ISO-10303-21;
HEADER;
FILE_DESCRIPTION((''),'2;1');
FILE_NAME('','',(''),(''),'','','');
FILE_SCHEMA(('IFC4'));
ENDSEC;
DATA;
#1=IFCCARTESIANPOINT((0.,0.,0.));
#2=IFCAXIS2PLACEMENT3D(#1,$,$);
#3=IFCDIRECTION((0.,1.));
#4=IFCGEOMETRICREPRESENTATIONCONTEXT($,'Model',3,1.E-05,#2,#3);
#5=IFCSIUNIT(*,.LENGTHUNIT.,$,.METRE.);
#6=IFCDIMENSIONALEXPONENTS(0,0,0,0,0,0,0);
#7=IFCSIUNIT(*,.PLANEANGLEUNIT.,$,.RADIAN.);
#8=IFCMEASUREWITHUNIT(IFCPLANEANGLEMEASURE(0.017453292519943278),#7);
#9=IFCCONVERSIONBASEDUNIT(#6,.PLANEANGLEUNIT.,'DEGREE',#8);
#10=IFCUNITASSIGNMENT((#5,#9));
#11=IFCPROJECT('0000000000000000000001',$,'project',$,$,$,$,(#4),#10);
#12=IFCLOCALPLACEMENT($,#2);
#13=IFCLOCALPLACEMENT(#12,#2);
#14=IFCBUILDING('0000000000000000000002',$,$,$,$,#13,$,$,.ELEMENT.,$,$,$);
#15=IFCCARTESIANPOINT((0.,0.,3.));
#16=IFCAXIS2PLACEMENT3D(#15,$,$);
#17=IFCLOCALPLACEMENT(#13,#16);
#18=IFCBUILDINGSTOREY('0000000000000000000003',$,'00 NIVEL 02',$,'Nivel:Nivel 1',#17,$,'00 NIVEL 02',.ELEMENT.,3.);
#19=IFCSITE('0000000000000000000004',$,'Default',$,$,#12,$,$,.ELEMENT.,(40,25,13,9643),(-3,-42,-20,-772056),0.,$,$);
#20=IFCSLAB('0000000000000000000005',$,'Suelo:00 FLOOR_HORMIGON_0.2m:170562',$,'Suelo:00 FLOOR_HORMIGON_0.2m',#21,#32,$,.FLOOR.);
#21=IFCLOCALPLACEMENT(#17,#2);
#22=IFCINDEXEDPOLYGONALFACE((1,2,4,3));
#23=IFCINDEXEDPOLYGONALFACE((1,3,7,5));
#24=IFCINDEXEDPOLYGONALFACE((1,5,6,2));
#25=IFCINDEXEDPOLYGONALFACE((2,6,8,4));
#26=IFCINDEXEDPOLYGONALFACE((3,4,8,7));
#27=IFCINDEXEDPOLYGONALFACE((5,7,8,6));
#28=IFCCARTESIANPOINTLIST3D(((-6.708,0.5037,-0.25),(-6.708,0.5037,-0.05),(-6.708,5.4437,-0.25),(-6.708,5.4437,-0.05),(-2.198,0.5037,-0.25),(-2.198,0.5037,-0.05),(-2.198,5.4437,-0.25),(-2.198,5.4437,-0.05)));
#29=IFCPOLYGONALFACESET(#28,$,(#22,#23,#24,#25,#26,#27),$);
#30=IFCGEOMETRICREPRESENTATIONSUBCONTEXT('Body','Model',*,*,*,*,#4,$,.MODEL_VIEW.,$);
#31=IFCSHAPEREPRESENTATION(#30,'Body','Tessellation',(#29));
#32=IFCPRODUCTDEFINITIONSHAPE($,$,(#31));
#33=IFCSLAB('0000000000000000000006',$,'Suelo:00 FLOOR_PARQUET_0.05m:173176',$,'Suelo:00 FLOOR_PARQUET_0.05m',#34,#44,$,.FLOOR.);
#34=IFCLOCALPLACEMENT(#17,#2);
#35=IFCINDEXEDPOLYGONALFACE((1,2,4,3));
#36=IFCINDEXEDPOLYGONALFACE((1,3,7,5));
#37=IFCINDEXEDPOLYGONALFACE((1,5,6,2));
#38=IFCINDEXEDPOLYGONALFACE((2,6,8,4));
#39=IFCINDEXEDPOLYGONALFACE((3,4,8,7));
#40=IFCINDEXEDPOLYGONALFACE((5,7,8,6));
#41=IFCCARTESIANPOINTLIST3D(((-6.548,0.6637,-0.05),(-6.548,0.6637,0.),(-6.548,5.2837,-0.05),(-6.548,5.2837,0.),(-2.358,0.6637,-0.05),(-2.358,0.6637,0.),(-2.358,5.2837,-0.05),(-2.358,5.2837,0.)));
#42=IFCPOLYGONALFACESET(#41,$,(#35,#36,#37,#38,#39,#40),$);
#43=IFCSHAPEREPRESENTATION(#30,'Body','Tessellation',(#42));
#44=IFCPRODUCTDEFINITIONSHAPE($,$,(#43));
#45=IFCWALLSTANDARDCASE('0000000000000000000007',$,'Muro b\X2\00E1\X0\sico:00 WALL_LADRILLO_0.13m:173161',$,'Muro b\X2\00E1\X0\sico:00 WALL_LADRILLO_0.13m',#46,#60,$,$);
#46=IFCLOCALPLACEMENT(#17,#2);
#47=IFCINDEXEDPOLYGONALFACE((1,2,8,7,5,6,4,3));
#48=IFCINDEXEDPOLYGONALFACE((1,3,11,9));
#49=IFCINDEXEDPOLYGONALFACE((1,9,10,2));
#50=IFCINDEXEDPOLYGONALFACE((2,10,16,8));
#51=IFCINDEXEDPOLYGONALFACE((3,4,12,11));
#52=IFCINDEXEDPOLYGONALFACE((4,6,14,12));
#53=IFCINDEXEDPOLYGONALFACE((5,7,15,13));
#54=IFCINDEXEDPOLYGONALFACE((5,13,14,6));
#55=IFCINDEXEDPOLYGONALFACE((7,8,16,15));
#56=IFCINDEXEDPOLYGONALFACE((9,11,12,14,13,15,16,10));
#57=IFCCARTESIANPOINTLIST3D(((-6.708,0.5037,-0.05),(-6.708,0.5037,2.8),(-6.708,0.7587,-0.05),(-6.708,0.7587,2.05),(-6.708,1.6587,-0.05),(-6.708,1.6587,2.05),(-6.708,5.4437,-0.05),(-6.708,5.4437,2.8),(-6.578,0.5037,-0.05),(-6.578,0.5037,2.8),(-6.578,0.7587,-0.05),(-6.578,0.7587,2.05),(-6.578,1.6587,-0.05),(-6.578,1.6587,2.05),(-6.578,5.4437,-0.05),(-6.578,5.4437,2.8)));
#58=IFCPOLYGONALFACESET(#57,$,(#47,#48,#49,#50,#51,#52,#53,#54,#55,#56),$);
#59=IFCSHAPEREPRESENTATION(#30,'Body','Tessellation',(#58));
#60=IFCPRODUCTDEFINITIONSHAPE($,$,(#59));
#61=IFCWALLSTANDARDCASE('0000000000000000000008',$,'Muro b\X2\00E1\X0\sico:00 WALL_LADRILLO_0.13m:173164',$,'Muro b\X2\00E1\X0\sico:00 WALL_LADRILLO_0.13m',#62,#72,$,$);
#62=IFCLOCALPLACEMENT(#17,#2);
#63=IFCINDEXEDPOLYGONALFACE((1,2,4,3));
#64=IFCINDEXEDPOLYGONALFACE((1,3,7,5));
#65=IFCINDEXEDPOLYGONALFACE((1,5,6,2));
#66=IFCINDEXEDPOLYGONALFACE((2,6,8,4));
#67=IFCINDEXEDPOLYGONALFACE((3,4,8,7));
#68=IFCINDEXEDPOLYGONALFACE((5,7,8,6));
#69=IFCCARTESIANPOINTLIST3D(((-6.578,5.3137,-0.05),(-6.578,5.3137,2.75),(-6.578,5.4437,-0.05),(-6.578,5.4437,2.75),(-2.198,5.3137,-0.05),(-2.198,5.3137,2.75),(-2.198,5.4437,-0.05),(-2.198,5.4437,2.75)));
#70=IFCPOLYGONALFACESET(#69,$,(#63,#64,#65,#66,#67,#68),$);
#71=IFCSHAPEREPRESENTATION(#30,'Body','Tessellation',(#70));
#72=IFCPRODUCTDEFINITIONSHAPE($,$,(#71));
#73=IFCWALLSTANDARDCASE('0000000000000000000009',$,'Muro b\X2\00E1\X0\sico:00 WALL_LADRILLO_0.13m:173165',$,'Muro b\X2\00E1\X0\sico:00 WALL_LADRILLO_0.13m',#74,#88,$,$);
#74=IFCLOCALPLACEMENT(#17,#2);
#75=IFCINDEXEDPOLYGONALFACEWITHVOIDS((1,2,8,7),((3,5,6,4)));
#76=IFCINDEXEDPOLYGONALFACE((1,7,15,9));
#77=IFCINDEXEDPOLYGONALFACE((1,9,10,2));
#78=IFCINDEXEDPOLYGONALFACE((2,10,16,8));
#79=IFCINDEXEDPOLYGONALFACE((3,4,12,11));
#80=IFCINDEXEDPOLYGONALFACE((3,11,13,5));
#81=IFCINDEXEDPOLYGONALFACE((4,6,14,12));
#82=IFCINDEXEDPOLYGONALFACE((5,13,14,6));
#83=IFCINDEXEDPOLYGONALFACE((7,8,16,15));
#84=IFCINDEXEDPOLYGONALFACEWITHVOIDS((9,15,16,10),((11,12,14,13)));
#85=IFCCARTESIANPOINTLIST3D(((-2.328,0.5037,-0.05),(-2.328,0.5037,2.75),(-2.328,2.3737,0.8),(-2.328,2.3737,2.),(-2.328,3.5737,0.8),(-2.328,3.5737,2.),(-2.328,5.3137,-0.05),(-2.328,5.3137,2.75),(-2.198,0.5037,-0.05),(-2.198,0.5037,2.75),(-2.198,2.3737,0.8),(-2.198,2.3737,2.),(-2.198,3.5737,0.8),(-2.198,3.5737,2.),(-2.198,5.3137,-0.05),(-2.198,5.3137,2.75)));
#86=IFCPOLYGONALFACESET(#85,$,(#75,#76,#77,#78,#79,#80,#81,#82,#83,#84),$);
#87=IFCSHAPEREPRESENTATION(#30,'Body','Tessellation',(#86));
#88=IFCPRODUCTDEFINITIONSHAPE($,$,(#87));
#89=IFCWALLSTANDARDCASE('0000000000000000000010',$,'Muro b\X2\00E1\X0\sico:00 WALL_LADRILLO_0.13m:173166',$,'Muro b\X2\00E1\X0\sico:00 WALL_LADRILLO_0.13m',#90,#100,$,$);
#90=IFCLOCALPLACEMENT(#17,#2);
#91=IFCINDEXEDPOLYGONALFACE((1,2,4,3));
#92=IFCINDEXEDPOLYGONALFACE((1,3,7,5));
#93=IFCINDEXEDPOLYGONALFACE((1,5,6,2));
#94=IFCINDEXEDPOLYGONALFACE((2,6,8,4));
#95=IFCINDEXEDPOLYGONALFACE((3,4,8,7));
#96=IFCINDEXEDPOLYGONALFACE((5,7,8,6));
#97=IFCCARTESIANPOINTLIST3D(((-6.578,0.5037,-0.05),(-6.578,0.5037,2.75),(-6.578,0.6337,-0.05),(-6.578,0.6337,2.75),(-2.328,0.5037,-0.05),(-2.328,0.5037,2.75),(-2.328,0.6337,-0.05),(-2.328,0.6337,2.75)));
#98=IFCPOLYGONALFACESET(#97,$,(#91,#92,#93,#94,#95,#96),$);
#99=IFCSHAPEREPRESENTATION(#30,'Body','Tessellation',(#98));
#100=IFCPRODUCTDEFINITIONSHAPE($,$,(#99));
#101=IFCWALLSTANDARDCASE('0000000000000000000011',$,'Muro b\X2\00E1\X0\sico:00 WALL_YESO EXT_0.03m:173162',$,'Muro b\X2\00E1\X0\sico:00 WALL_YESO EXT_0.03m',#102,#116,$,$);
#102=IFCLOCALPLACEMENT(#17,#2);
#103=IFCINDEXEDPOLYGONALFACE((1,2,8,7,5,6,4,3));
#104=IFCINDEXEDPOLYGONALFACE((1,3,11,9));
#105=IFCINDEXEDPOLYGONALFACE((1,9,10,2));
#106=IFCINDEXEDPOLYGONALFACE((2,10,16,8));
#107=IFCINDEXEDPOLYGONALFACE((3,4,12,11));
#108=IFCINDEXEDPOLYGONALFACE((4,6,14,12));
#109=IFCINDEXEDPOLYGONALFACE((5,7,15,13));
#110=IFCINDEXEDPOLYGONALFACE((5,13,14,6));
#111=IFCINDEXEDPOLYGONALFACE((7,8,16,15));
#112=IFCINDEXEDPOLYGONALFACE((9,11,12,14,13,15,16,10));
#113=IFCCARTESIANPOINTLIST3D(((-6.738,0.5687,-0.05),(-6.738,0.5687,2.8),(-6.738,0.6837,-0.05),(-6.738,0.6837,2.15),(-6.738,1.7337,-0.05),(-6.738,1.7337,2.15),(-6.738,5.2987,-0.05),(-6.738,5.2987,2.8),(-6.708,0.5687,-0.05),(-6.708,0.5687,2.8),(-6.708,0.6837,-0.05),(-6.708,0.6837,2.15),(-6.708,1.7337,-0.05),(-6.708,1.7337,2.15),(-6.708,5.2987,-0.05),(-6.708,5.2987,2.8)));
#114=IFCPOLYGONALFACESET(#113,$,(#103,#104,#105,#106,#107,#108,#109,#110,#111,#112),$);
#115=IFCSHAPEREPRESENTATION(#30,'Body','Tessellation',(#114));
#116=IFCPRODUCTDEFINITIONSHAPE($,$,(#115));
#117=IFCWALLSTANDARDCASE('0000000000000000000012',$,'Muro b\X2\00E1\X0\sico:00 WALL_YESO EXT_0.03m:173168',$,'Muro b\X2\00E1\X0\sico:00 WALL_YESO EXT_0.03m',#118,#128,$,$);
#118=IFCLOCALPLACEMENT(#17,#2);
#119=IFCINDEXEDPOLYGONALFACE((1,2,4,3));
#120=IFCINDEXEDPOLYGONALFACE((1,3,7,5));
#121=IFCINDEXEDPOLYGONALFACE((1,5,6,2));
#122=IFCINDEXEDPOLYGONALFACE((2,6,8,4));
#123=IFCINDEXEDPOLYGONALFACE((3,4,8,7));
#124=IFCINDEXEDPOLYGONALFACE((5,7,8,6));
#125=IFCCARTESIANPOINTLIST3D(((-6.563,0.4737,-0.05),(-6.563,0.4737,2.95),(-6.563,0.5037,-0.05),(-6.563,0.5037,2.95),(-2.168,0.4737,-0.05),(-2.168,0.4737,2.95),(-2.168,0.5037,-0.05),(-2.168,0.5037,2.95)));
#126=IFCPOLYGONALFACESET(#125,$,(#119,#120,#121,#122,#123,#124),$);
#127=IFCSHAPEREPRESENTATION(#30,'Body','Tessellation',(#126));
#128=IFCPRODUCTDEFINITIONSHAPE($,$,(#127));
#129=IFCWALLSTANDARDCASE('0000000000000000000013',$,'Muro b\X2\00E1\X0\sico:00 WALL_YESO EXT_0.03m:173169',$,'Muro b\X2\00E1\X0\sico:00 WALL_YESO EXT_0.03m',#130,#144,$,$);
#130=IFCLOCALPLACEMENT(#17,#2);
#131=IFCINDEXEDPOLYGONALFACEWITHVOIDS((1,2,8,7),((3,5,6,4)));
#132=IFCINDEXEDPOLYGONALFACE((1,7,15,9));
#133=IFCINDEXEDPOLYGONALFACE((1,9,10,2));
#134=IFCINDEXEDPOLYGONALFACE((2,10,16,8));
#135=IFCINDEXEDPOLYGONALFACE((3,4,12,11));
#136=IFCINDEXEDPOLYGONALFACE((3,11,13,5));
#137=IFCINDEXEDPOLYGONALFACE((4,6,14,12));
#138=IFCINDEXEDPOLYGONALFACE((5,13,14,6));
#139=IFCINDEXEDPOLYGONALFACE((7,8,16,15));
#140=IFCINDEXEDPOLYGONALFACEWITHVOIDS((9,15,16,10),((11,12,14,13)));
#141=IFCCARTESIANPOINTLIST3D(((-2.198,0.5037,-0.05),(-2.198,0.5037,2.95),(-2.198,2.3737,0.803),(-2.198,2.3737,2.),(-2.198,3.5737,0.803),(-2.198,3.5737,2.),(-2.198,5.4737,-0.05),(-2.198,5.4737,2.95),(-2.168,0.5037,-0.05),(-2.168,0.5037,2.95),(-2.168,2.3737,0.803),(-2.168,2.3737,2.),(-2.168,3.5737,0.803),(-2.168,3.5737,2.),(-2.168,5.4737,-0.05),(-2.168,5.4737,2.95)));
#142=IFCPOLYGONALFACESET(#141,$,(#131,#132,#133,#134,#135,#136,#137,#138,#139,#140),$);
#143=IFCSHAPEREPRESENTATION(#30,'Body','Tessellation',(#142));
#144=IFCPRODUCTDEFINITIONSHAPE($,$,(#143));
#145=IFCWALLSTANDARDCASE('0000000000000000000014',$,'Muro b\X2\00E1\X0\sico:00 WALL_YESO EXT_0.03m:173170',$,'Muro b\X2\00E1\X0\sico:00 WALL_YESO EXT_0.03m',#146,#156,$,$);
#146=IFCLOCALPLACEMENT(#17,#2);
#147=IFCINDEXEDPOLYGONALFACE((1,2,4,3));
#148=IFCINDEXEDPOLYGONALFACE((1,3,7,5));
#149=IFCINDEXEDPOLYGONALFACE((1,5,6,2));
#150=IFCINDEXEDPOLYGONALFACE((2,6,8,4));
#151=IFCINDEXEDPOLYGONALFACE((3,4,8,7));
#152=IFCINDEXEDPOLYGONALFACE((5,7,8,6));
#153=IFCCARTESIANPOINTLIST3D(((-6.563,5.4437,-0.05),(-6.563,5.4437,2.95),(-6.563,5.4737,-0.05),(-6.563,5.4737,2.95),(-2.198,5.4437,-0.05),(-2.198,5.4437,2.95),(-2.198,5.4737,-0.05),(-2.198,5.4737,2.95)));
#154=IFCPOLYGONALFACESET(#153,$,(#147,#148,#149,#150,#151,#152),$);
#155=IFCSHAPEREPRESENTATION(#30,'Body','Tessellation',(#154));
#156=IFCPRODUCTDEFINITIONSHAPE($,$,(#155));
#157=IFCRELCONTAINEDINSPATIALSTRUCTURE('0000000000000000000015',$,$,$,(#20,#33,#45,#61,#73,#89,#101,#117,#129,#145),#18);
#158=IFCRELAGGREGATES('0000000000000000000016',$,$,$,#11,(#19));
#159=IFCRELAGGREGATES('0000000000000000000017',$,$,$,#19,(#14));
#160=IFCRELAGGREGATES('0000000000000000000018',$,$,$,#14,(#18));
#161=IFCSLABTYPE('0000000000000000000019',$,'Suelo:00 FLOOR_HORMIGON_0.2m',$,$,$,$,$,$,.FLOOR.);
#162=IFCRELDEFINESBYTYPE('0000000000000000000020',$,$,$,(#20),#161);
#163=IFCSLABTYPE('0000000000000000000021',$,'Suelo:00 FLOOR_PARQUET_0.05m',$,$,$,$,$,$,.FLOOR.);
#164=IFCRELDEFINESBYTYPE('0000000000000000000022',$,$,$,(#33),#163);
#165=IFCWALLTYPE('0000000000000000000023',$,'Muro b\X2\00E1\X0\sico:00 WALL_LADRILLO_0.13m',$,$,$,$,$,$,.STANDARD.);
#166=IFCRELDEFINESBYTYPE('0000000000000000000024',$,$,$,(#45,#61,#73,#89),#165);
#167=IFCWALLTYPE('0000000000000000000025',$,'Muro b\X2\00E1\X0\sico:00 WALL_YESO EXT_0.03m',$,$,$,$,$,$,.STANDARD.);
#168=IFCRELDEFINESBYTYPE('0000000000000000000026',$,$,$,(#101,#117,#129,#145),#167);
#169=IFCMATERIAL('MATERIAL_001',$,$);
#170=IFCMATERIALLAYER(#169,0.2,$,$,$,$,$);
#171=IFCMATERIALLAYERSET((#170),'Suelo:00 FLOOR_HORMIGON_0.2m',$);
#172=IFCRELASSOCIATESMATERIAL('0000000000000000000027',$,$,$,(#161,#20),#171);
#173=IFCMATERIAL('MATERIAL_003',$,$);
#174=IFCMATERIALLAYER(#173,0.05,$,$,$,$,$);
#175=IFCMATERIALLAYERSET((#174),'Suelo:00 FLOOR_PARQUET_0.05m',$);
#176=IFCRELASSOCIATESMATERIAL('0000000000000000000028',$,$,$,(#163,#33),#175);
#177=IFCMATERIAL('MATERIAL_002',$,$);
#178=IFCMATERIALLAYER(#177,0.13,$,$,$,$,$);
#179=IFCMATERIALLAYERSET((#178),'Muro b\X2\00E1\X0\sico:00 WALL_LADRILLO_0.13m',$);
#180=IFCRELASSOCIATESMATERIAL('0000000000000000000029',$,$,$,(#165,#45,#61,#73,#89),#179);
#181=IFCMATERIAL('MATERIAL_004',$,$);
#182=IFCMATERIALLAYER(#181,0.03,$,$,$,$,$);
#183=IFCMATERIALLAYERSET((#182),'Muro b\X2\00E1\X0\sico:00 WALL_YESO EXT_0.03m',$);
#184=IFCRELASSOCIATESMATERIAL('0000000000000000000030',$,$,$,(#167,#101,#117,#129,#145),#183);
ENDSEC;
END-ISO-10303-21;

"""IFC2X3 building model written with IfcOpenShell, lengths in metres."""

from ifc_helpers import new_model, entity, si_unit, converted_unit, direction, frame, frame_2d, origin, place, context, subcontext, project, spatial, rectangle, extrude, material, layer, layer_set, layer_usage, type_object, element, save


model = new_model("IFC2X3")

# Units and contexts
model_context = context("Model", 3, precision=1e-05, world=origin(), true_north=direction((0.0, 1.0)))
body_context = subcontext(model_context, "Body", "Model", "MODEL_VIEW")
ifc_project = project(units=[si_unit("LENGTHUNIT", "METRE"), converted_unit("PLANEANGLEUNIT", "DEGREE", entity("IfcPlaneAngleMeasure", 0.017453292519943278), si_unit("PLANEANGLEUNIT", "RADIAN"), dimensions=[0, 0, 0, 0, 0, 0, 0])], contexts=[model_context])

# Site, building, storey
site_placement = place(None, origin())
site = spatial("IfcSite", under=ifc_project, at=site_placement, Name="Default", CompositionType="ELEMENT", RefLatitude=(40, 25, 13, 9643), RefLongitude=(-3, -42, -20, -772056), RefElevation=0.0)
building_placement = place(site_placement, origin())
building = spatial("IfcBuilding", under=site, at=building_placement, CompositionType="ELEMENT")
storey_placement = place(building_placement, frame((0.0, 0.0, 3.0)))
storey = spatial("IfcBuildingStorey", under=building, at=storey_placement, Name="00 NIVEL 02", ObjectType="Nivel:Nivel 1", LongName="00 NIVEL 02", CompositionType="ELEMENT", Elevation=3.0)

# Slabs
ifc_material_1 = material(Name="MATERIAL_001")
ifc_layer_1 = layer(ifc_material_1, 0.2)
ifc_layer_set_1 = layer_set([ifc_layer_1], Name="Suelo:00 FLOOR_HORMIGON_0.2m")
ifc_layer_usage_1 = layer_usage(ifc_layer_set_1, "AXIS3", "POSITIVE", 0.0)
slab_type_1 = type_object("IfcSlabType", Name="Suelo:00 FLOOR_HORMIGON_0.2m", PredefinedType="FLOOR", material=ifc_layer_set_1)
slab_1_placement = place(storey_placement, origin())
element("IfcSlab", 1, at=slab_1_placement, inside=storey, type_object=slab_type_1, material=ifc_layer_usage_1, Name="Suelo:00 FLOOR_HORMIGON_0.2m:170562", ObjectType="Suelo:00 FLOOR_HORMIGON_0.2m", PredefinedType="FLOOR", context=body_context, shape_type="SweptSolid", body=[
    extrude(rectangle(XDim=4.94, YDim=4.51, at=frame_2d((0.0, 0.0), x_axis=(1.0, 0.0))), frame((-4.453, 2.9737, -0.05), z_axis=(0.0, 0.0, -1.0), x_axis=(0.0, 1.0, 0.0)), (0.0, 0.0, 1.0), 0.2),
])
ifc_material_2 = material(Name="MATERIAL_003")
ifc_layer_2 = layer(ifc_material_2, 0.05)
ifc_layer_set_2 = layer_set([ifc_layer_2], Name="Suelo:00 FLOOR_PARQUET_0.05m")
ifc_layer_usage_2 = layer_usage(ifc_layer_set_2, "AXIS3", "POSITIVE", 0.0)
slab_type_2 = type_object("IfcSlabType", Name="Suelo:00 FLOOR_PARQUET_0.05m", PredefinedType="FLOOR", material=ifc_layer_set_2)
slab_2_placement = place(storey_placement, origin())
element("IfcSlab", 2, at=slab_2_placement, inside=storey, type_object=slab_type_2, material=ifc_layer_usage_2, Name="Suelo:00 FLOOR_PARQUET_0.05m:173176", ObjectType="Suelo:00 FLOOR_PARQUET_0.05m", PredefinedType="FLOOR", context=body_context, shape_type="SweptSolid", body=[
    extrude(rectangle(XDim=4.62, YDim=4.19, at=frame_2d((0.0, 0.0), x_axis=(1.0, 0.0))), frame((-4.453, 2.9737, 0.0), z_axis=(0.0, 0.0, -1.0), x_axis=(0.0, 1.0, 0.0)), (0.0, 0.0, 1.0), 0.05),
])

# Wall, opening
ifc_material_3 = material(Name="MATERIAL_002")
ifc_layer_3 = layer(ifc_material_3, 0.13)
ifc_layer_set_3 = layer_set([ifc_layer_3], Name="Muro básico:00 WALL_LADRILLO_0.13m")
ifc_layer_usage_3 = layer_usage(ifc_layer_set_3, "AXIS2", "NEGATIVE", 0.065)
wall_type_1 = type_object("IfcWallType", Name="Muro básico:00 WALL_LADRILLO_0.13m", PredefinedType="STANDARD", material=ifc_layer_set_3)
wall_1_placement = place(storey_placement, frame((-6.643, 5.4437, -0.05), z_axis=(0.0, 0.0, 1.0), x_axis=(0.0, -1.0, 0.0)))
wall_1 = element("IfcWallStandardCase", 3, at=wall_1_placement, inside=storey, type_object=wall_type_1, material=ifc_layer_usage_3, Name="Muro básico:00 WALL_LADRILLO_0.13m:173161", ObjectType="Muro básico:00 WALL_LADRILLO_0.13m", context=body_context, shape_type="SweptSolid", body=[
    extrude(rectangle(XDim=4.94, YDim=0.13, at=frame_2d((2.47, 0.0), x_axis=(-1.0, 0.0))), origin(), (0.0, 0.0, 1.0), 2.85),
])
opening_1_placement = place(wall_1_placement, frame((3.785, -0.065, 0.0)))
element("IfcOpeningElement", 4, at=opening_1_placement, cuts=wall_1, ObjectType="Opening", context=body_context, shape_type="SweptSolid", body=[
    extrude(rectangle(XDim=2.1, YDim=0.9, at=frame_2d((1.05, 0.45), x_axis=(1.0, 0.0))), frame((0.0, 0.0, 0.0), z_axis=(0.0, 1.0, 0.0), x_axis=(0.0, 0.0, 1.0)), (0.0, 0.0, 1.0), 0.13),
])

# Wall
ifc_layer_usage_4 = layer_usage(ifc_layer_set_3, "AXIS2", "NEGATIVE", 0.065)
wall_2_placement = place(storey_placement, frame((-6.578, 5.3787, -0.05)))
element("IfcWallStandardCase", 5, at=wall_2_placement, inside=storey, type_object=wall_type_1, material=ifc_layer_usage_4, Name="Muro básico:00 WALL_LADRILLO_0.13m:173164", ObjectType="Muro básico:00 WALL_LADRILLO_0.13m", context=body_context, shape_type="SweptSolid", body=[
    extrude(rectangle(XDim=4.38, YDim=0.13, at=frame_2d((2.19, 0.0), x_axis=(-1.0, 0.0))), origin(), (0.0, 0.0, 1.0), 2.8),
])

# Wall, opening
ifc_layer_usage_5 = layer_usage(ifc_layer_set_3, "AXIS2", "NEGATIVE", 0.065)
wall_3_placement = place(storey_placement, frame((-2.263, 5.3137, -0.05), z_axis=(0.0, 0.0, 1.0), x_axis=(0.0, -1.0, 0.0)))
wall_3 = element("IfcWallStandardCase", 6, at=wall_3_placement, inside=storey, type_object=wall_type_1, material=ifc_layer_usage_5, Name="Muro básico:00 WALL_LADRILLO_0.13m:173165", ObjectType="Muro básico:00 WALL_LADRILLO_0.13m", context=body_context, shape_type="SweptSolid", body=[
    extrude(rectangle(XDim=4.81, YDim=0.13, at=frame_2d((2.405, 0.0), x_axis=(-1.0, 0.0))), origin(), (0.0, 0.0, 1.0), 2.8),
])
opening_2_placement = place(wall_3_placement, frame((2.94, 0.065, 0.85)))
element("IfcOpeningElement", 7, at=opening_2_placement, cuts=wall_3, ObjectType="Opening", context=body_context, shape_type="SweptSolid", body=[
    extrude(rectangle(XDim=1.2, YDim=1.2, at=frame_2d((0.6, 0.6), x_axis=(1.0, 0.0))), frame((0.0, 0.0, 0.0), z_axis=(0.0, -1.0, 0.0), x_axis=(0.0, 0.0, 1.0)), (0.0, 0.0, 1.0), 0.13),
])

# Wall
ifc_layer_usage_6 = layer_usage(ifc_layer_set_3, "AXIS2", "POSITIVE", -0.065)
wall_4_placement = place(storey_placement, frame((-6.578, 0.5687, -0.05)))
element("IfcWallStandardCase", 8, at=wall_4_placement, inside=storey, type_object=wall_type_1, material=ifc_layer_usage_6, Name="Muro básico:00 WALL_LADRILLO_0.13m:173166", ObjectType="Muro básico:00 WALL_LADRILLO_0.13m", context=body_context, shape_type="SweptSolid", body=[
    extrude(rectangle(XDim=4.25, YDim=0.13, at=frame_2d((2.125, 0.0), x_axis=(-1.0, 0.0))), origin(), (0.0, 0.0, 1.0), 2.8),
])

# Wall, opening
ifc_material_4 = material(Name="MATERIAL_004")
ifc_layer_4 = layer(ifc_material_4, 0.03)
ifc_layer_set_4 = layer_set([ifc_layer_4], Name="Muro básico:00 WALL_YESO EXT_0.03m")
ifc_layer_usage_7 = layer_usage(ifc_layer_set_4, "AXIS2", "NEGATIVE", 0.015)
wall_type_2 = type_object("IfcWallType", Name="Muro básico:00 WALL_YESO EXT_0.03m", PredefinedType="STANDARD", material=ifc_layer_set_4)
wall_5_placement = place(storey_placement, frame((-6.723, 5.2987, -0.05), z_axis=(0.0, 0.0, 1.0), x_axis=(0.0, -1.0, 0.0)))
wall_5 = element("IfcWallStandardCase", 9, at=wall_5_placement, inside=storey, type_object=wall_type_2, material=ifc_layer_usage_7, Name="Muro básico:00 WALL_YESO EXT_0.03m:173162", ObjectType="Muro básico:00 WALL_YESO EXT_0.03m", context=body_context, shape_type="SweptSolid", body=[
    extrude(rectangle(XDim=4.73, YDim=0.03, at=frame_2d((2.365, 0.0), x_axis=(-1.0, 0.0))), origin(), (0.0, 0.0, 1.0), 2.85),
])
opening_3_placement = place(wall_5_placement, origin())
element("IfcOpeningElement", 10, at=opening_3_placement, cuts=wall_5, ObjectType="Opening", context=body_context, shape_type="SweptSolid", body=[
    extrude(rectangle(XDim=2.2, YDim=1.05, at=frame_2d((0.0, 0.0), x_axis=(0.0, 1.0))), frame((4.09, 0.015, 1.1), z_axis=(0.0, -1.0, 0.0), x_axis=(1.0, 0.0, 0.0)), (0.0, 0.0, 1.0), 0.03),
])

# Wall
ifc_layer_usage_8 = layer_usage(ifc_layer_set_4, "AXIS2", "NEGATIVE", 0.015)
wall_6_placement = place(storey_placement, frame((-6.563, 0.4887, -0.05)))
element("IfcWallStandardCase", 11, at=wall_6_placement, inside=storey, type_object=wall_type_2, material=ifc_layer_usage_8, Name="Muro básico:00 WALL_YESO EXT_0.03m:173168", ObjectType="Muro básico:00 WALL_YESO EXT_0.03m", context=body_context, shape_type="SweptSolid", body=[
    extrude(rectangle(XDim=4.395, YDim=0.03, at=frame_2d((2.1975, 0.0), x_axis=(-1.0, 0.0))), origin(), (0.0, 0.0, 1.0), 3.0),
])

# Wall, opening
ifc_layer_usage_9 = layer_usage(ifc_layer_set_4, "AXIS2", "NEGATIVE", 0.015)
wall_7_placement = place(storey_placement, frame((-2.183, 0.5037, -0.05), z_axis=(0.0, 0.0, 1.0), x_axis=(0.0, 1.0, 0.0)))
wall_7 = element("IfcWallStandardCase", 12, at=wall_7_placement, inside=storey, type_object=wall_type_2, material=ifc_layer_usage_9, Name="Muro básico:00 WALL_YESO EXT_0.03m:173169", ObjectType="Muro básico:00 WALL_YESO EXT_0.03m", context=body_context, shape_type="SweptSolid", body=[
    extrude(rectangle(XDim=4.97, YDim=0.03, at=frame_2d((2.485, 0.0), x_axis=(-1.0, 0.0))), origin(), (0.0, 0.0, 1.0), 3.0),
])
opening_4_placement = place(wall_7_placement, origin())
element("IfcOpeningElement", 13, at=opening_4_placement, cuts=wall_7, ObjectType="Opening", context=body_context, shape_type="SweptSolid", body=[
    extrude(rectangle(XDim=1.197, YDim=1.2, at=frame_2d((0.0, 0.0), x_axis=(0.0, 1.0))), frame((2.47, 0.015, 1.4515), z_axis=(0.0, -1.0, 0.0), x_axis=(-1.0, 0.0, 0.0)), (0.0, 0.0, 1.0), 0.03),
])

# Wall
ifc_layer_usage_10 = layer_usage(ifc_layer_set_4, "AXIS2", "NEGATIVE", 0.015)
wall_8_placement = place(storey_placement, frame((-2.198, 5.4587, -0.05), z_axis=(0.0, 0.0, 1.0), x_axis=(-1.0, 0.0, 0.0)))
element("IfcWallStandardCase", 14, at=wall_8_placement, inside=storey, type_object=wall_type_2, material=ifc_layer_usage_10, Name="Muro básico:00 WALL_YESO EXT_0.03m:173170", ObjectType="Muro básico:00 WALL_YESO EXT_0.03m", context=body_context, shape_type="SweptSolid", body=[
    extrude(rectangle(XDim=4.365, YDim=0.03, at=frame_2d((2.1825, 0.0), x_axis=(-1.0, 0.0))), origin(), (0.0, 0.0, 1.0), 3.0),
])

save(model, "model.ifc")
